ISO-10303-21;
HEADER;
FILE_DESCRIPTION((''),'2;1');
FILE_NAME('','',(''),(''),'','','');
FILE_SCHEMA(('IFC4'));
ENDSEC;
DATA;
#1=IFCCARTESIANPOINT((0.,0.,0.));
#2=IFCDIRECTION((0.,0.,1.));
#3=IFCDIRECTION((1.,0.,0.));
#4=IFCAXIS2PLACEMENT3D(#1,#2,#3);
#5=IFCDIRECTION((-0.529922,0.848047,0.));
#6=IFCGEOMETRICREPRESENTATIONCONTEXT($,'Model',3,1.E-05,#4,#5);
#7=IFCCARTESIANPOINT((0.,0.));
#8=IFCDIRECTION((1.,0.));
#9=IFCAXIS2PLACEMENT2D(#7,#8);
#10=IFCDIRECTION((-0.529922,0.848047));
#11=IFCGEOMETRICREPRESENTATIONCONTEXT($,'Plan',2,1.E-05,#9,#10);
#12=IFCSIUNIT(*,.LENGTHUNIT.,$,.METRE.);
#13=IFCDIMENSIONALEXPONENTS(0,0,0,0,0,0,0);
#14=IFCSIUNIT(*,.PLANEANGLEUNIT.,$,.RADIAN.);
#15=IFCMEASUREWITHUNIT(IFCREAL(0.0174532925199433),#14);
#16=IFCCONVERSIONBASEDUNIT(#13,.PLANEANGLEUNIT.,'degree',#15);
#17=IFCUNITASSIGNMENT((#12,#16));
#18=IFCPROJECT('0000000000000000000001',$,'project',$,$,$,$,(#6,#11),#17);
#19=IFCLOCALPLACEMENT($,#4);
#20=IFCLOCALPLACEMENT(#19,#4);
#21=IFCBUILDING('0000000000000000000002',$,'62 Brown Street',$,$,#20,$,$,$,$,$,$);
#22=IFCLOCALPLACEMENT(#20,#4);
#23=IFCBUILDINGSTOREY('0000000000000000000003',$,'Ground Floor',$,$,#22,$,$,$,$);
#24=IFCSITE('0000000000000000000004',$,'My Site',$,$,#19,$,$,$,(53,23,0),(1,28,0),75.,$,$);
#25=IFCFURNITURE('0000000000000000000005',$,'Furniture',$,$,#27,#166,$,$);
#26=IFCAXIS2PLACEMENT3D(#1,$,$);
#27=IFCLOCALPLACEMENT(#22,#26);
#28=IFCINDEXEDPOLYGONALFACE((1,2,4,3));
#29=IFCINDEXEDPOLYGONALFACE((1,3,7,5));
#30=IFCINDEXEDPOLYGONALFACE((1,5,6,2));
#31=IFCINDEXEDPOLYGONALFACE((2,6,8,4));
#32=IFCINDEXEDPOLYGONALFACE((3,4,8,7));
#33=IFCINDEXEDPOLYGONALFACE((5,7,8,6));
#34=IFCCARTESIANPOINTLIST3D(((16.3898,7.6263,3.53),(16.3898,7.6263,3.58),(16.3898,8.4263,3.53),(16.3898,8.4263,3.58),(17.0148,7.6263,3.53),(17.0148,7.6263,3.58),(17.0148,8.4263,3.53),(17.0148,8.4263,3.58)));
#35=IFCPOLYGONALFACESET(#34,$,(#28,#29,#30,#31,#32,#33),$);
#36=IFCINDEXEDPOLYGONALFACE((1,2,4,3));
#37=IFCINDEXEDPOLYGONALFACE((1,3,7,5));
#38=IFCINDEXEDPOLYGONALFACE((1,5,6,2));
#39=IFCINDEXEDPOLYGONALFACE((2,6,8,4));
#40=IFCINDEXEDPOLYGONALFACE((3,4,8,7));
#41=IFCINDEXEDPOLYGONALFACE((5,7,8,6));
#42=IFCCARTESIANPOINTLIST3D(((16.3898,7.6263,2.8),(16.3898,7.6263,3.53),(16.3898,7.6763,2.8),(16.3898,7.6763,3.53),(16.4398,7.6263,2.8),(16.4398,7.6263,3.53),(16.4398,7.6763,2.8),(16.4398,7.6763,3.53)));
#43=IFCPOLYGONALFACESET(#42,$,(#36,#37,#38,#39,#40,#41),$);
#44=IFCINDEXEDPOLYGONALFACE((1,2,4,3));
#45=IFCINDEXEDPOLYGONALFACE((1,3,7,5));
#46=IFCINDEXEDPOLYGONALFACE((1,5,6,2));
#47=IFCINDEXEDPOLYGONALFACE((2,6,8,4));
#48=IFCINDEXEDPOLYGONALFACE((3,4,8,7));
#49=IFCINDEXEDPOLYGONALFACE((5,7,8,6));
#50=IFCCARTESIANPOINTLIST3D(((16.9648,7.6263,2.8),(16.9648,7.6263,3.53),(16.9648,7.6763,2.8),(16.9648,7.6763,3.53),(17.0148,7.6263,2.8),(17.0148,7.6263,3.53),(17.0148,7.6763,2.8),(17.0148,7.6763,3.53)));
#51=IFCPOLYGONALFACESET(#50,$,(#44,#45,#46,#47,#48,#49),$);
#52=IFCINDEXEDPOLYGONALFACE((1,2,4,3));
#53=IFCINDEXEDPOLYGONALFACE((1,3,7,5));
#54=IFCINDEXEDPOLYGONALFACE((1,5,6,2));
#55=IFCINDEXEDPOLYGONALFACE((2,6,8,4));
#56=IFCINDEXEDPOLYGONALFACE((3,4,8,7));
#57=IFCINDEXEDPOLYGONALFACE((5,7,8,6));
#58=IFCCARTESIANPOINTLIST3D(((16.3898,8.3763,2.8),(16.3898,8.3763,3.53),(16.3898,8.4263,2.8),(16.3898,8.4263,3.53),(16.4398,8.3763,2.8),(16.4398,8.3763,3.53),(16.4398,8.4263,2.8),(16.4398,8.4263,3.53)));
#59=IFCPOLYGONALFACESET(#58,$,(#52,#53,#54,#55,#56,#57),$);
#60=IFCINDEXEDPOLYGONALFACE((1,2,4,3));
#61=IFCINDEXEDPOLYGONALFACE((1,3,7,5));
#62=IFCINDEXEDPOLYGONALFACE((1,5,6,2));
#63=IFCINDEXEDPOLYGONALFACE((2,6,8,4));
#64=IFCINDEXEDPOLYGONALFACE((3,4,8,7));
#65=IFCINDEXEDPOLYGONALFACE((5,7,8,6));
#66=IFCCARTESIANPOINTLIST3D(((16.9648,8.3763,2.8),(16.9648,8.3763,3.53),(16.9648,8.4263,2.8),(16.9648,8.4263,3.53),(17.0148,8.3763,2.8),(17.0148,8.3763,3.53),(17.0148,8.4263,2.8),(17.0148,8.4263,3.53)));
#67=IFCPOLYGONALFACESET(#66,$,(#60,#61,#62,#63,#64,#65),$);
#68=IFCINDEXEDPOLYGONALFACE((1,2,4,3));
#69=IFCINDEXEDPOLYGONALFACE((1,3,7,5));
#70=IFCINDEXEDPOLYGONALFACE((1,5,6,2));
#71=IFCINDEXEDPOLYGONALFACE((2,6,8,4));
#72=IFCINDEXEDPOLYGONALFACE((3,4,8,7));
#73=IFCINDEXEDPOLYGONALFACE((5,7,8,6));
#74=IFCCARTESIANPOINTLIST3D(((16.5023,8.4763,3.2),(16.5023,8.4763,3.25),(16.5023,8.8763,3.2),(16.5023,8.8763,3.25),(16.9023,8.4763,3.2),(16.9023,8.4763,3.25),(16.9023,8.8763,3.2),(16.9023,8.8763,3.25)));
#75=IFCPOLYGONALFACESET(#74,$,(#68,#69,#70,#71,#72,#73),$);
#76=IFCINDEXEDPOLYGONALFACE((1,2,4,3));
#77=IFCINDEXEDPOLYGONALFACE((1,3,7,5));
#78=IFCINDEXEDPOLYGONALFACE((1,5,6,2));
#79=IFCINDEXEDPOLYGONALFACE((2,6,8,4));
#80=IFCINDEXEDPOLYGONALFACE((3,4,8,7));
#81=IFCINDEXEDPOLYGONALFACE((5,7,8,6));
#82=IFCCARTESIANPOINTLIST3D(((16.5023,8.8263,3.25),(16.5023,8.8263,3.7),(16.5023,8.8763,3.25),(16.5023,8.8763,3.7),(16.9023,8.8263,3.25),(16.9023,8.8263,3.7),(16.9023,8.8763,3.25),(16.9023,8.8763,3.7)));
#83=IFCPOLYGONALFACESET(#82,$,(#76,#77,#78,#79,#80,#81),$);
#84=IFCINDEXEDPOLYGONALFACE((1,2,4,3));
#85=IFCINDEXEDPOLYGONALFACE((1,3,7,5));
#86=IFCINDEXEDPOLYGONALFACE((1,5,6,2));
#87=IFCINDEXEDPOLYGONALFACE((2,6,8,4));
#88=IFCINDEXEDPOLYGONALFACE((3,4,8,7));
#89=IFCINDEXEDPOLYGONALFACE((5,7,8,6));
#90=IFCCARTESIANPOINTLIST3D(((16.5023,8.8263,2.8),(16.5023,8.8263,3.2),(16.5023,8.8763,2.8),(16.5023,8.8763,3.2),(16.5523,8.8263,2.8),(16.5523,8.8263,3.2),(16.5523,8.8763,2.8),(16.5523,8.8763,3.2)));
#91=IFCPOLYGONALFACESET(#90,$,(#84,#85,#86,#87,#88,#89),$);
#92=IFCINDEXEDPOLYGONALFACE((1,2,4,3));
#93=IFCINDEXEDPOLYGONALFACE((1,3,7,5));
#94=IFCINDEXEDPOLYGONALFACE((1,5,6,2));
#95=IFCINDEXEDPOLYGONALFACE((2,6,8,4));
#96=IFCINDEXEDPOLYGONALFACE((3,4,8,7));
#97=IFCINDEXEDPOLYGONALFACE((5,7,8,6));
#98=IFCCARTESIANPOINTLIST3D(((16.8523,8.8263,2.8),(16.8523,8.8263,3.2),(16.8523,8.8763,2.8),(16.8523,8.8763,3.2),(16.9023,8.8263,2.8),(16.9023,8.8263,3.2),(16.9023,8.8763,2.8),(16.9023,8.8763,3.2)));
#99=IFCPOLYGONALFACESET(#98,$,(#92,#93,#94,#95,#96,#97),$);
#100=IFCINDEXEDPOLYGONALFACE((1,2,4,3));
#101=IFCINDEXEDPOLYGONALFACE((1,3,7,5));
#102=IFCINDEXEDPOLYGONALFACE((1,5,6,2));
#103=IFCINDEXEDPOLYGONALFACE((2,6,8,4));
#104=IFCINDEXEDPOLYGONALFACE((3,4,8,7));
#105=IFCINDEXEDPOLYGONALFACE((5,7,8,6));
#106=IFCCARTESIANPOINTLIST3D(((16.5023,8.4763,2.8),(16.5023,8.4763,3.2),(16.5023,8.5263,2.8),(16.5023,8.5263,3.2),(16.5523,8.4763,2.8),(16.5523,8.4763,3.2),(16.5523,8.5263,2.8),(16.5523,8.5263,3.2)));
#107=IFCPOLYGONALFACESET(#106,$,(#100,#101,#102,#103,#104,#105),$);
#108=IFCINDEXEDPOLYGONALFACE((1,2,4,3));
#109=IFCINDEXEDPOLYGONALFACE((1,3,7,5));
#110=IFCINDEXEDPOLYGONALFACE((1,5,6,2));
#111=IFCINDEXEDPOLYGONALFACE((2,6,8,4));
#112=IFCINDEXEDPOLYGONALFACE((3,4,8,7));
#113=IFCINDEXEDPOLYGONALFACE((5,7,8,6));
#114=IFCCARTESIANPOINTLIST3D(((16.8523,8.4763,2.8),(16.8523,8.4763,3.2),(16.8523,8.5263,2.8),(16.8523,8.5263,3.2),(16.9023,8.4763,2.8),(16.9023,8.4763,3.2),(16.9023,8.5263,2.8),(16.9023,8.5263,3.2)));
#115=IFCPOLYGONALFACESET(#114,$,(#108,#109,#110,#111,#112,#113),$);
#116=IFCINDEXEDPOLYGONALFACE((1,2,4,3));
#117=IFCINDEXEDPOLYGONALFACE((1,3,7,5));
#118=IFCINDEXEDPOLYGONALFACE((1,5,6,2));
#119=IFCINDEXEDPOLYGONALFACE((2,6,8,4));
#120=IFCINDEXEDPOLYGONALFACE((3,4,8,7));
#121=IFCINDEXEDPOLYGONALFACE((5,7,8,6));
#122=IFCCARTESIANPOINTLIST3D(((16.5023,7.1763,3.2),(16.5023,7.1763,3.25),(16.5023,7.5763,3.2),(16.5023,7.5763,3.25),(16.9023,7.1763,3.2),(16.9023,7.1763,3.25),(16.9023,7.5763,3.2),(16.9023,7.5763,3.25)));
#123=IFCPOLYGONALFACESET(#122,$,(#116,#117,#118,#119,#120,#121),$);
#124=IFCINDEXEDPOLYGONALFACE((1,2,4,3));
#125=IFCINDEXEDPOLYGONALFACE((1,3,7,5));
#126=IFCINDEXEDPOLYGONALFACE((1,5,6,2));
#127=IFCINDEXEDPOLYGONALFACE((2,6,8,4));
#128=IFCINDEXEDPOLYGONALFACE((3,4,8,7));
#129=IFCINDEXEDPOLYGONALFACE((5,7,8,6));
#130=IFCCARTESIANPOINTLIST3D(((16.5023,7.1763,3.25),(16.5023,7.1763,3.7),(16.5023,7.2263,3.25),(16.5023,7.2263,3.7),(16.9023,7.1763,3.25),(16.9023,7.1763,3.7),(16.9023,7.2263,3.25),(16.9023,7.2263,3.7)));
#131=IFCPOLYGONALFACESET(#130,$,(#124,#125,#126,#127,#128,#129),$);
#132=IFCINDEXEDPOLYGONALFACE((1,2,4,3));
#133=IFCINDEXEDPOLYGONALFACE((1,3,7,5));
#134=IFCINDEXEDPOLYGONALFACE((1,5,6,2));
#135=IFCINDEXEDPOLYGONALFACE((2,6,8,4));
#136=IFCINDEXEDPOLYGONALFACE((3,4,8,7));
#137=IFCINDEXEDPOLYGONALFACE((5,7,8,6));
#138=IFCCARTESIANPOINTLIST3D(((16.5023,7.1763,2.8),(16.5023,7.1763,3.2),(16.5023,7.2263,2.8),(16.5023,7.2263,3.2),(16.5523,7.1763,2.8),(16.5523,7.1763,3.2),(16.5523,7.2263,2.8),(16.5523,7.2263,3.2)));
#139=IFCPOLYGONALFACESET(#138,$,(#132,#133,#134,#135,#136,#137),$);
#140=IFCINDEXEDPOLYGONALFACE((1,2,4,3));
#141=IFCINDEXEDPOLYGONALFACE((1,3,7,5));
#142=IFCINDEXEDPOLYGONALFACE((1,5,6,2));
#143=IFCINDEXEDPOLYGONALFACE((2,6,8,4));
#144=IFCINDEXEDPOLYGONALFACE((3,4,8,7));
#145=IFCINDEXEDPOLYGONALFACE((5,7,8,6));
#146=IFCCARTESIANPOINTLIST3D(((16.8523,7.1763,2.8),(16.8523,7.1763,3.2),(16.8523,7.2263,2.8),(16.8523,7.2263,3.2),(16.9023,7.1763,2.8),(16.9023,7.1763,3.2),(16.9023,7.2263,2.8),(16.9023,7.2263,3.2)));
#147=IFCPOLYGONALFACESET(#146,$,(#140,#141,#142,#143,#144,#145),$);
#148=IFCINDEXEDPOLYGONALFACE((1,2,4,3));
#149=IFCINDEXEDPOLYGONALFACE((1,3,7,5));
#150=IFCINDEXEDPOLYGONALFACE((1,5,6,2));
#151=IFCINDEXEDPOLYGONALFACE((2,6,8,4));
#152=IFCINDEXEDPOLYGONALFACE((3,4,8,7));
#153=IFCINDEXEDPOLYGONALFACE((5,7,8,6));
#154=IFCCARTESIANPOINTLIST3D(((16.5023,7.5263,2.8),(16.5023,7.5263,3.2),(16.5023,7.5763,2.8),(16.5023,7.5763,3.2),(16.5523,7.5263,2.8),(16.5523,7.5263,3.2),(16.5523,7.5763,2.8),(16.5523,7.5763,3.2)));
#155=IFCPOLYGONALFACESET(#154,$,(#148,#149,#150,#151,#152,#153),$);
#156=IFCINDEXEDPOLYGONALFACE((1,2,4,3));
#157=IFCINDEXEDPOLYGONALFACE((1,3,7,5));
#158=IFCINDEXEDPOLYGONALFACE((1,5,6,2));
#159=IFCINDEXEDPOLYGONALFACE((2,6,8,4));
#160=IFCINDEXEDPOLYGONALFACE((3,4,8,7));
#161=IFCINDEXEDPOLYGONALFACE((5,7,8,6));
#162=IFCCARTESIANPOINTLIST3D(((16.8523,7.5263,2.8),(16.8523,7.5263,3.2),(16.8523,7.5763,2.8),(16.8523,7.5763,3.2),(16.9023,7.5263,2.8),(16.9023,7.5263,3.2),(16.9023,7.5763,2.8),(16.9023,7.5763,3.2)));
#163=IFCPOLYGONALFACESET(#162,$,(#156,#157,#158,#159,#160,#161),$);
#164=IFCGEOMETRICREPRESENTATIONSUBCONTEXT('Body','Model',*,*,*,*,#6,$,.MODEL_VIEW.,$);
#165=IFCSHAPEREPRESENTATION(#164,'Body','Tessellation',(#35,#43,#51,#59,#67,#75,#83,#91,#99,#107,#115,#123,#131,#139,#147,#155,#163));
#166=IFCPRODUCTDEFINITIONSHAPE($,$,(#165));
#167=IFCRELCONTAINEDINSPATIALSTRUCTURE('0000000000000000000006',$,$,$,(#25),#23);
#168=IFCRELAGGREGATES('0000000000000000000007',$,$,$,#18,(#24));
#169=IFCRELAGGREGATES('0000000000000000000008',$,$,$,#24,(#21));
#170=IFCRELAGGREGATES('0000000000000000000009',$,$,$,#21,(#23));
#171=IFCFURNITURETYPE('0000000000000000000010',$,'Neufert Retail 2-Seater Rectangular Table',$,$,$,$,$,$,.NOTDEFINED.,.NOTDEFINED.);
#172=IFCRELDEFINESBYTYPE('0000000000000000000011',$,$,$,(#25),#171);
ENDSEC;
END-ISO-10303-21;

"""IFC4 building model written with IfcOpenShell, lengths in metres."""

from ifc_helpers import new_model, entity, si_unit, converted_unit, direction, frame, origin_with_axes, origin_2d_with_axis, place, context, subcontext, project, spatial, line, indexed_curve, outline, extrude, shape, source, transform, mapped, type_object, type_shapes, element, save


model = new_model("IFC4")

# Units and contexts
model_context = context("Model", 3, precision=1e-05, world=origin_with_axes(), true_north=direction((-0.529922, 0.848047, 0.0)))
plan_context = context("Plan", 2, precision=1e-05, world=origin_2d_with_axis(), true_north=direction((-0.529922, 0.848047)))
body_context_1 = subcontext(model_context, "Body", "Model", "MODEL_VIEW")
body_context_2 = subcontext(plan_context, "Body", "Plan", "PLAN_VIEW")
ifc_project = project(units=[si_unit("LENGTHUNIT", "METRE"), converted_unit("PLANEANGLEUNIT", "degree", entity("IfcReal", 0.0174532925199433), si_unit("PLANEANGLEUNIT", "RADIAN"), dimensions=[0, 0, 0, 0, 0, 0, 0])], contexts=[model_context, plan_context])

# Site, building, storey
site_placement = place(None, origin_with_axes())
site = spatial("IfcSite", under=ifc_project, at=site_placement, Name="My Site", RefLatitude=(53, 23, 0), RefLongitude=(1, 28, 0), RefElevation=75.0)
building_placement = place(site_placement, origin_with_axes())
building = spatial("IfcBuilding", under=site, at=building_placement, Name="62 Brown Street")
storey_placement = place(building_placement, origin_with_axes())
storey = spatial("IfcBuildingStorey", under=building, at=storey_placement, Name="Ground Floor")

# Furniture
furniture_type_1 = type_object("IfcFurnitureType", Name="Neufert Retail 2-Seater Rectangular Table", AssemblyPlace="NOTDEFINED", PredefinedType="NOTDEFINED")
shared_shape_1 = source(origin_with_axes(), body_context_1, "Body", "SweptSolid", [
    extrude(outline(indexed_curve([(0.0, 0.0), (0.625, 0.0), (0.625, 0.8), (0.0, 0.8)], segments=[line(1, 2, 3, 4, 1)])), frame((-0.3125, -0.4, 0.73), z_axis=(0.0, 0.0, 1.0), x_axis=(1.0, 0.0, 0.0)), (0.0, 0.0, 1.0), 0.05),
    extrude(outline(indexed_curve([(0.0, 0.0), (0.05, 0.0), (0.05, 0.05), (0.0, 0.05)], segments=[line(1, 2, 3, 4, 1)])), frame((-0.3125, -0.4, 0.0), z_axis=(0.0, 0.0, 1.0), x_axis=(1.0, 0.0, 0.0)), (0.0, 0.0, 1.0), 0.73),
    extrude(outline(indexed_curve([(0.625, 0.0), (0.575, 0.0), (0.575, 0.05), (0.625, 0.05)], segments=[line(1, 2, 3, 4, 1)])), frame((-0.3125, -0.4, 0.0), z_axis=(0.0, 0.0, 1.0), x_axis=(1.0, 0.0, 0.0)), (0.0, 0.0, 1.0), 0.73),
    extrude(outline(indexed_curve([(0.0, 0.8), (0.05, 0.8), (0.05, 0.75), (0.0, 0.75)], segments=[line(1, 2, 3, 4, 1)])), frame((-0.3125, -0.4, 0.0), z_axis=(0.0, 0.0, 1.0), x_axis=(1.0, 0.0, 0.0)), (0.0, 0.0, 1.0), 0.73),
    extrude(outline(indexed_curve([(0.625, 0.8), (0.575, 0.8), (0.575, 0.75), (0.625, 0.75)], segments=[line(1, 2, 3, 4, 1)])), frame((-0.3125, -0.4, 0.0), z_axis=(0.0, 0.0, 1.0), x_axis=(1.0, 0.0, 0.0)), (0.0, 0.0, 1.0), 0.73),
    extrude(outline(indexed_curve([(-0.2, 0.0), (0.2, 0.0), (0.2, -0.4), (-0.2, -0.4)], segments=[line(1, 2, 3, 4, 1)])), frame((0.0, 0.85, 0.45), z_axis=(0.0, 0.0, 1.0), x_axis=(1.0, 0.0, 0.0)), (0.0, 0.0, -1.0), 0.05),
    extrude(outline(indexed_curve([(-0.2, 0.0), (0.2, 0.0), (0.2, -0.05), (-0.2, -0.05)], segments=[line(1, 2, 3, 4, 1)])), frame((0.0, 0.85, 0.9), z_axis=(0.0, 0.0, 1.0), x_axis=(1.0, 0.0, 0.0)), (0.0, 0.0, -1.0), 0.45),
    extrude(outline(indexed_curve([(-0.2, 0.0), (-0.15, 0.0), (-0.15, -0.05), (-0.2, -0.05)], segments=[line(1, 2, 3, 4, 1)])), frame((0.0, 0.85, 0.0), z_axis=(0.0, 0.0, 1.0), x_axis=(1.0, 0.0, 0.0)), (0.0, 0.0, 1.0), 0.4),
    extrude(outline(indexed_curve([(0.2, 0.0), (0.15, 0.0), (0.15, -0.05), (0.2, -0.05)], segments=[line(1, 2, 3, 4, 1)])), frame((0.0, 0.85, 0.0), z_axis=(0.0, 0.0, 1.0), x_axis=(1.0, 0.0, 0.0)), (0.0, 0.0, 1.0), 0.4),
    extrude(outline(indexed_curve([(-0.2, -0.4), (-0.15, -0.4), (-0.15, -0.35), (-0.2, -0.35)], segments=[line(1, 2, 3, 4, 1)])), frame((0.0, 0.85, 0.0), z_axis=(0.0, 0.0, 1.0), x_axis=(1.0, 0.0, 0.0)), (0.0, 0.0, 1.0), 0.4),
    extrude(outline(indexed_curve([(0.2, -0.4), (0.15, -0.4), (0.15, -0.35), (0.2, -0.35)], segments=[line(1, 2, 3, 4, 1)])), frame((0.0, 0.85, 0.0), z_axis=(0.0, 0.0, 1.0), x_axis=(1.0, 0.0, 0.0)), (0.0, 0.0, 1.0), 0.4),
    extrude(outline(indexed_curve([(-0.2, 0.0), (0.2, 0.0), (0.2, 0.4), (-0.2, 0.4)], segments=[line(1, 2, 3, 4, 1)])), frame((0.0, -0.85, 0.45), z_axis=(0.0, 0.0, 1.0), x_axis=(1.0, 0.0, 0.0)), (0.0, 0.0, -1.0), 0.05),
    extrude(outline(indexed_curve([(-0.2, 0.0), (0.2, 0.0), (0.2, 0.05), (-0.2, 0.05)], segments=[line(1, 2, 3, 4, 1)])), frame((0.0, -0.85, 0.9), z_axis=(0.0, 0.0, 1.0), x_axis=(1.0, 0.0, 0.0)), (0.0, 0.0, -1.0), 0.45),
    extrude(outline(indexed_curve([(-0.2, 0.0), (-0.15, 0.0), (-0.15, 0.05), (-0.2, 0.05)], segments=[line(1, 2, 3, 4, 1)])), frame((0.0, -0.85, 0.0), z_axis=(0.0, 0.0, 1.0), x_axis=(1.0, 0.0, 0.0)), (0.0, 0.0, 1.0), 0.4),
    extrude(outline(indexed_curve([(0.2, 0.0), (0.15, 0.0), (0.15, 0.05), (0.2, 0.05)], segments=[line(1, 2, 3, 4, 1)])), frame((0.0, -0.85, 0.0), z_axis=(0.0, 0.0, 1.0), x_axis=(1.0, 0.0, 0.0)), (0.0, 0.0, 1.0), 0.4),
    extrude(outline(indexed_curve([(-0.2, 0.4), (-0.15, 0.4), (-0.15, 0.35), (-0.2, 0.35)], segments=[line(1, 2, 3, 4, 1)])), frame((0.0, -0.85, 0.0), z_axis=(0.0, 0.0, 1.0), x_axis=(1.0, 0.0, 0.0)), (0.0, 0.0, 1.0), 0.4),
    extrude(outline(indexed_curve([(0.2, 0.4), (0.15, 0.4), (0.15, 0.35), (0.2, 0.35)], segments=[line(1, 2, 3, 4, 1)])), frame((0.0, -0.85, 0.0), z_axis=(0.0, 0.0, 1.0), x_axis=(1.0, 0.0, 0.0)), (0.0, 0.0, 1.0), 0.4),
])
shared_shape_2 = source(origin_with_axes(), body_context_2, "Body", "Curve2D", [
    entity("IfcIndexedPolyCurve", entity("IfcCartesianPointList2D", [[-0.3125, -0.4], [0.3125, -0.4], [0.3125, 0.4], [-0.3125, 0.4]]), [entity("IfcLineIndex", [1, 2, 3, 4, 1])]),
    entity("IfcIndexedPolyCurve", entity("IfcCartesianPointList2D", [[-0.2, 0.45], [0.2, 0.45]])),
    entity("IfcIndexedPolyCurve", entity("IfcCartesianPointList2D", [[-0.2, 0.45], [-0.2, 0.65], [-0.1414, 0.7914], [0.0, 0.85], [0.1414, 0.7914], [0.2, 0.65], [0.2, 0.45]]), [entity("IfcLineIndex", [1, 2]), entity("IfcArcIndex", [2, 3, 4]), entity("IfcArcIndex", [4, 5, 6]), entity("IfcLineIndex", [6, 7])]),
    entity("IfcIndexedPolyCurve", entity("IfcCartesianPointList2D", [[-0.16, 0.45], [-0.16, 0.65], [-0.1131, 0.7631], [0.0, 0.81], [0.1131, 0.7631], [0.16, 0.65], [0.16, 0.45]]), [entity("IfcLineIndex", [1, 2]), entity("IfcArcIndex", [2, 3, 4]), entity("IfcArcIndex", [4, 5, 6]), entity("IfcLineIndex", [6, 7])]),
    entity("IfcIndexedPolyCurve", entity("IfcCartesianPointList2D", [[-0.2, -0.45], [0.2, -0.45]])),
    entity("IfcIndexedPolyCurve", entity("IfcCartesianPointList2D", [[-0.2, -0.45], [-0.2, -0.65], [-0.1414, -0.7914], [0.0, -0.85], [0.1414, -0.7914], [0.2, -0.65], [0.2, -0.45]]), [entity("IfcLineIndex", [1, 2]), entity("IfcArcIndex", [2, 3, 4]), entity("IfcArcIndex", [4, 5, 6]), entity("IfcLineIndex", [6, 7])]),
    entity("IfcIndexedPolyCurve", entity("IfcCartesianPointList2D", [[-0.16, -0.45], [-0.16, -0.65], [-0.1131, -0.7631], [0.0, -0.81], [0.1131, -0.7631], [0.16, -0.65], [0.16, -0.45]]), [entity("IfcLineIndex", [1, 2]), entity("IfcArcIndex", [2, 3, 4]), entity("IfcArcIndex", [4, 5, 6]), entity("IfcLineIndex", [6, 7])]),
])
type_shapes(furniture_type_1, [shared_shape_1, shared_shape_2])
furniture_1_placement = place(storey_placement, frame((16.7023, 8.0263, 2.8), z_axis=(0.0, 0.0, 1.0), x_axis=(1.0, 0.0, 0.0)))
element("IfcFurniture", 1, at=furniture_1_placement, inside=storey, type_object=furniture_type_1, Name="Furniture", shapes=[
    shape(body_context_1, "Body", "MappedRepresentation", [mapped(shared_shape_1, transform((0.0, 0.0, 0.0), x_axis=(1.0, 0.0, 0.0), y_axis=(0.0, 1.0, 0.0), z_axis=(0.0, 0.0, 1.0), scale=1.0))]),
    shape(body_context_2, "Body", "MappedRepresentation", [mapped(shared_shape_2, transform((0.0, 0.0, 0.0), x_axis=(1.0, 0.0, 0.0), y_axis=(0.0, 1.0, 0.0), z_axis=(0.0, 0.0, 1.0), scale=1.0))]),
])

save(model, "model.ifc")
